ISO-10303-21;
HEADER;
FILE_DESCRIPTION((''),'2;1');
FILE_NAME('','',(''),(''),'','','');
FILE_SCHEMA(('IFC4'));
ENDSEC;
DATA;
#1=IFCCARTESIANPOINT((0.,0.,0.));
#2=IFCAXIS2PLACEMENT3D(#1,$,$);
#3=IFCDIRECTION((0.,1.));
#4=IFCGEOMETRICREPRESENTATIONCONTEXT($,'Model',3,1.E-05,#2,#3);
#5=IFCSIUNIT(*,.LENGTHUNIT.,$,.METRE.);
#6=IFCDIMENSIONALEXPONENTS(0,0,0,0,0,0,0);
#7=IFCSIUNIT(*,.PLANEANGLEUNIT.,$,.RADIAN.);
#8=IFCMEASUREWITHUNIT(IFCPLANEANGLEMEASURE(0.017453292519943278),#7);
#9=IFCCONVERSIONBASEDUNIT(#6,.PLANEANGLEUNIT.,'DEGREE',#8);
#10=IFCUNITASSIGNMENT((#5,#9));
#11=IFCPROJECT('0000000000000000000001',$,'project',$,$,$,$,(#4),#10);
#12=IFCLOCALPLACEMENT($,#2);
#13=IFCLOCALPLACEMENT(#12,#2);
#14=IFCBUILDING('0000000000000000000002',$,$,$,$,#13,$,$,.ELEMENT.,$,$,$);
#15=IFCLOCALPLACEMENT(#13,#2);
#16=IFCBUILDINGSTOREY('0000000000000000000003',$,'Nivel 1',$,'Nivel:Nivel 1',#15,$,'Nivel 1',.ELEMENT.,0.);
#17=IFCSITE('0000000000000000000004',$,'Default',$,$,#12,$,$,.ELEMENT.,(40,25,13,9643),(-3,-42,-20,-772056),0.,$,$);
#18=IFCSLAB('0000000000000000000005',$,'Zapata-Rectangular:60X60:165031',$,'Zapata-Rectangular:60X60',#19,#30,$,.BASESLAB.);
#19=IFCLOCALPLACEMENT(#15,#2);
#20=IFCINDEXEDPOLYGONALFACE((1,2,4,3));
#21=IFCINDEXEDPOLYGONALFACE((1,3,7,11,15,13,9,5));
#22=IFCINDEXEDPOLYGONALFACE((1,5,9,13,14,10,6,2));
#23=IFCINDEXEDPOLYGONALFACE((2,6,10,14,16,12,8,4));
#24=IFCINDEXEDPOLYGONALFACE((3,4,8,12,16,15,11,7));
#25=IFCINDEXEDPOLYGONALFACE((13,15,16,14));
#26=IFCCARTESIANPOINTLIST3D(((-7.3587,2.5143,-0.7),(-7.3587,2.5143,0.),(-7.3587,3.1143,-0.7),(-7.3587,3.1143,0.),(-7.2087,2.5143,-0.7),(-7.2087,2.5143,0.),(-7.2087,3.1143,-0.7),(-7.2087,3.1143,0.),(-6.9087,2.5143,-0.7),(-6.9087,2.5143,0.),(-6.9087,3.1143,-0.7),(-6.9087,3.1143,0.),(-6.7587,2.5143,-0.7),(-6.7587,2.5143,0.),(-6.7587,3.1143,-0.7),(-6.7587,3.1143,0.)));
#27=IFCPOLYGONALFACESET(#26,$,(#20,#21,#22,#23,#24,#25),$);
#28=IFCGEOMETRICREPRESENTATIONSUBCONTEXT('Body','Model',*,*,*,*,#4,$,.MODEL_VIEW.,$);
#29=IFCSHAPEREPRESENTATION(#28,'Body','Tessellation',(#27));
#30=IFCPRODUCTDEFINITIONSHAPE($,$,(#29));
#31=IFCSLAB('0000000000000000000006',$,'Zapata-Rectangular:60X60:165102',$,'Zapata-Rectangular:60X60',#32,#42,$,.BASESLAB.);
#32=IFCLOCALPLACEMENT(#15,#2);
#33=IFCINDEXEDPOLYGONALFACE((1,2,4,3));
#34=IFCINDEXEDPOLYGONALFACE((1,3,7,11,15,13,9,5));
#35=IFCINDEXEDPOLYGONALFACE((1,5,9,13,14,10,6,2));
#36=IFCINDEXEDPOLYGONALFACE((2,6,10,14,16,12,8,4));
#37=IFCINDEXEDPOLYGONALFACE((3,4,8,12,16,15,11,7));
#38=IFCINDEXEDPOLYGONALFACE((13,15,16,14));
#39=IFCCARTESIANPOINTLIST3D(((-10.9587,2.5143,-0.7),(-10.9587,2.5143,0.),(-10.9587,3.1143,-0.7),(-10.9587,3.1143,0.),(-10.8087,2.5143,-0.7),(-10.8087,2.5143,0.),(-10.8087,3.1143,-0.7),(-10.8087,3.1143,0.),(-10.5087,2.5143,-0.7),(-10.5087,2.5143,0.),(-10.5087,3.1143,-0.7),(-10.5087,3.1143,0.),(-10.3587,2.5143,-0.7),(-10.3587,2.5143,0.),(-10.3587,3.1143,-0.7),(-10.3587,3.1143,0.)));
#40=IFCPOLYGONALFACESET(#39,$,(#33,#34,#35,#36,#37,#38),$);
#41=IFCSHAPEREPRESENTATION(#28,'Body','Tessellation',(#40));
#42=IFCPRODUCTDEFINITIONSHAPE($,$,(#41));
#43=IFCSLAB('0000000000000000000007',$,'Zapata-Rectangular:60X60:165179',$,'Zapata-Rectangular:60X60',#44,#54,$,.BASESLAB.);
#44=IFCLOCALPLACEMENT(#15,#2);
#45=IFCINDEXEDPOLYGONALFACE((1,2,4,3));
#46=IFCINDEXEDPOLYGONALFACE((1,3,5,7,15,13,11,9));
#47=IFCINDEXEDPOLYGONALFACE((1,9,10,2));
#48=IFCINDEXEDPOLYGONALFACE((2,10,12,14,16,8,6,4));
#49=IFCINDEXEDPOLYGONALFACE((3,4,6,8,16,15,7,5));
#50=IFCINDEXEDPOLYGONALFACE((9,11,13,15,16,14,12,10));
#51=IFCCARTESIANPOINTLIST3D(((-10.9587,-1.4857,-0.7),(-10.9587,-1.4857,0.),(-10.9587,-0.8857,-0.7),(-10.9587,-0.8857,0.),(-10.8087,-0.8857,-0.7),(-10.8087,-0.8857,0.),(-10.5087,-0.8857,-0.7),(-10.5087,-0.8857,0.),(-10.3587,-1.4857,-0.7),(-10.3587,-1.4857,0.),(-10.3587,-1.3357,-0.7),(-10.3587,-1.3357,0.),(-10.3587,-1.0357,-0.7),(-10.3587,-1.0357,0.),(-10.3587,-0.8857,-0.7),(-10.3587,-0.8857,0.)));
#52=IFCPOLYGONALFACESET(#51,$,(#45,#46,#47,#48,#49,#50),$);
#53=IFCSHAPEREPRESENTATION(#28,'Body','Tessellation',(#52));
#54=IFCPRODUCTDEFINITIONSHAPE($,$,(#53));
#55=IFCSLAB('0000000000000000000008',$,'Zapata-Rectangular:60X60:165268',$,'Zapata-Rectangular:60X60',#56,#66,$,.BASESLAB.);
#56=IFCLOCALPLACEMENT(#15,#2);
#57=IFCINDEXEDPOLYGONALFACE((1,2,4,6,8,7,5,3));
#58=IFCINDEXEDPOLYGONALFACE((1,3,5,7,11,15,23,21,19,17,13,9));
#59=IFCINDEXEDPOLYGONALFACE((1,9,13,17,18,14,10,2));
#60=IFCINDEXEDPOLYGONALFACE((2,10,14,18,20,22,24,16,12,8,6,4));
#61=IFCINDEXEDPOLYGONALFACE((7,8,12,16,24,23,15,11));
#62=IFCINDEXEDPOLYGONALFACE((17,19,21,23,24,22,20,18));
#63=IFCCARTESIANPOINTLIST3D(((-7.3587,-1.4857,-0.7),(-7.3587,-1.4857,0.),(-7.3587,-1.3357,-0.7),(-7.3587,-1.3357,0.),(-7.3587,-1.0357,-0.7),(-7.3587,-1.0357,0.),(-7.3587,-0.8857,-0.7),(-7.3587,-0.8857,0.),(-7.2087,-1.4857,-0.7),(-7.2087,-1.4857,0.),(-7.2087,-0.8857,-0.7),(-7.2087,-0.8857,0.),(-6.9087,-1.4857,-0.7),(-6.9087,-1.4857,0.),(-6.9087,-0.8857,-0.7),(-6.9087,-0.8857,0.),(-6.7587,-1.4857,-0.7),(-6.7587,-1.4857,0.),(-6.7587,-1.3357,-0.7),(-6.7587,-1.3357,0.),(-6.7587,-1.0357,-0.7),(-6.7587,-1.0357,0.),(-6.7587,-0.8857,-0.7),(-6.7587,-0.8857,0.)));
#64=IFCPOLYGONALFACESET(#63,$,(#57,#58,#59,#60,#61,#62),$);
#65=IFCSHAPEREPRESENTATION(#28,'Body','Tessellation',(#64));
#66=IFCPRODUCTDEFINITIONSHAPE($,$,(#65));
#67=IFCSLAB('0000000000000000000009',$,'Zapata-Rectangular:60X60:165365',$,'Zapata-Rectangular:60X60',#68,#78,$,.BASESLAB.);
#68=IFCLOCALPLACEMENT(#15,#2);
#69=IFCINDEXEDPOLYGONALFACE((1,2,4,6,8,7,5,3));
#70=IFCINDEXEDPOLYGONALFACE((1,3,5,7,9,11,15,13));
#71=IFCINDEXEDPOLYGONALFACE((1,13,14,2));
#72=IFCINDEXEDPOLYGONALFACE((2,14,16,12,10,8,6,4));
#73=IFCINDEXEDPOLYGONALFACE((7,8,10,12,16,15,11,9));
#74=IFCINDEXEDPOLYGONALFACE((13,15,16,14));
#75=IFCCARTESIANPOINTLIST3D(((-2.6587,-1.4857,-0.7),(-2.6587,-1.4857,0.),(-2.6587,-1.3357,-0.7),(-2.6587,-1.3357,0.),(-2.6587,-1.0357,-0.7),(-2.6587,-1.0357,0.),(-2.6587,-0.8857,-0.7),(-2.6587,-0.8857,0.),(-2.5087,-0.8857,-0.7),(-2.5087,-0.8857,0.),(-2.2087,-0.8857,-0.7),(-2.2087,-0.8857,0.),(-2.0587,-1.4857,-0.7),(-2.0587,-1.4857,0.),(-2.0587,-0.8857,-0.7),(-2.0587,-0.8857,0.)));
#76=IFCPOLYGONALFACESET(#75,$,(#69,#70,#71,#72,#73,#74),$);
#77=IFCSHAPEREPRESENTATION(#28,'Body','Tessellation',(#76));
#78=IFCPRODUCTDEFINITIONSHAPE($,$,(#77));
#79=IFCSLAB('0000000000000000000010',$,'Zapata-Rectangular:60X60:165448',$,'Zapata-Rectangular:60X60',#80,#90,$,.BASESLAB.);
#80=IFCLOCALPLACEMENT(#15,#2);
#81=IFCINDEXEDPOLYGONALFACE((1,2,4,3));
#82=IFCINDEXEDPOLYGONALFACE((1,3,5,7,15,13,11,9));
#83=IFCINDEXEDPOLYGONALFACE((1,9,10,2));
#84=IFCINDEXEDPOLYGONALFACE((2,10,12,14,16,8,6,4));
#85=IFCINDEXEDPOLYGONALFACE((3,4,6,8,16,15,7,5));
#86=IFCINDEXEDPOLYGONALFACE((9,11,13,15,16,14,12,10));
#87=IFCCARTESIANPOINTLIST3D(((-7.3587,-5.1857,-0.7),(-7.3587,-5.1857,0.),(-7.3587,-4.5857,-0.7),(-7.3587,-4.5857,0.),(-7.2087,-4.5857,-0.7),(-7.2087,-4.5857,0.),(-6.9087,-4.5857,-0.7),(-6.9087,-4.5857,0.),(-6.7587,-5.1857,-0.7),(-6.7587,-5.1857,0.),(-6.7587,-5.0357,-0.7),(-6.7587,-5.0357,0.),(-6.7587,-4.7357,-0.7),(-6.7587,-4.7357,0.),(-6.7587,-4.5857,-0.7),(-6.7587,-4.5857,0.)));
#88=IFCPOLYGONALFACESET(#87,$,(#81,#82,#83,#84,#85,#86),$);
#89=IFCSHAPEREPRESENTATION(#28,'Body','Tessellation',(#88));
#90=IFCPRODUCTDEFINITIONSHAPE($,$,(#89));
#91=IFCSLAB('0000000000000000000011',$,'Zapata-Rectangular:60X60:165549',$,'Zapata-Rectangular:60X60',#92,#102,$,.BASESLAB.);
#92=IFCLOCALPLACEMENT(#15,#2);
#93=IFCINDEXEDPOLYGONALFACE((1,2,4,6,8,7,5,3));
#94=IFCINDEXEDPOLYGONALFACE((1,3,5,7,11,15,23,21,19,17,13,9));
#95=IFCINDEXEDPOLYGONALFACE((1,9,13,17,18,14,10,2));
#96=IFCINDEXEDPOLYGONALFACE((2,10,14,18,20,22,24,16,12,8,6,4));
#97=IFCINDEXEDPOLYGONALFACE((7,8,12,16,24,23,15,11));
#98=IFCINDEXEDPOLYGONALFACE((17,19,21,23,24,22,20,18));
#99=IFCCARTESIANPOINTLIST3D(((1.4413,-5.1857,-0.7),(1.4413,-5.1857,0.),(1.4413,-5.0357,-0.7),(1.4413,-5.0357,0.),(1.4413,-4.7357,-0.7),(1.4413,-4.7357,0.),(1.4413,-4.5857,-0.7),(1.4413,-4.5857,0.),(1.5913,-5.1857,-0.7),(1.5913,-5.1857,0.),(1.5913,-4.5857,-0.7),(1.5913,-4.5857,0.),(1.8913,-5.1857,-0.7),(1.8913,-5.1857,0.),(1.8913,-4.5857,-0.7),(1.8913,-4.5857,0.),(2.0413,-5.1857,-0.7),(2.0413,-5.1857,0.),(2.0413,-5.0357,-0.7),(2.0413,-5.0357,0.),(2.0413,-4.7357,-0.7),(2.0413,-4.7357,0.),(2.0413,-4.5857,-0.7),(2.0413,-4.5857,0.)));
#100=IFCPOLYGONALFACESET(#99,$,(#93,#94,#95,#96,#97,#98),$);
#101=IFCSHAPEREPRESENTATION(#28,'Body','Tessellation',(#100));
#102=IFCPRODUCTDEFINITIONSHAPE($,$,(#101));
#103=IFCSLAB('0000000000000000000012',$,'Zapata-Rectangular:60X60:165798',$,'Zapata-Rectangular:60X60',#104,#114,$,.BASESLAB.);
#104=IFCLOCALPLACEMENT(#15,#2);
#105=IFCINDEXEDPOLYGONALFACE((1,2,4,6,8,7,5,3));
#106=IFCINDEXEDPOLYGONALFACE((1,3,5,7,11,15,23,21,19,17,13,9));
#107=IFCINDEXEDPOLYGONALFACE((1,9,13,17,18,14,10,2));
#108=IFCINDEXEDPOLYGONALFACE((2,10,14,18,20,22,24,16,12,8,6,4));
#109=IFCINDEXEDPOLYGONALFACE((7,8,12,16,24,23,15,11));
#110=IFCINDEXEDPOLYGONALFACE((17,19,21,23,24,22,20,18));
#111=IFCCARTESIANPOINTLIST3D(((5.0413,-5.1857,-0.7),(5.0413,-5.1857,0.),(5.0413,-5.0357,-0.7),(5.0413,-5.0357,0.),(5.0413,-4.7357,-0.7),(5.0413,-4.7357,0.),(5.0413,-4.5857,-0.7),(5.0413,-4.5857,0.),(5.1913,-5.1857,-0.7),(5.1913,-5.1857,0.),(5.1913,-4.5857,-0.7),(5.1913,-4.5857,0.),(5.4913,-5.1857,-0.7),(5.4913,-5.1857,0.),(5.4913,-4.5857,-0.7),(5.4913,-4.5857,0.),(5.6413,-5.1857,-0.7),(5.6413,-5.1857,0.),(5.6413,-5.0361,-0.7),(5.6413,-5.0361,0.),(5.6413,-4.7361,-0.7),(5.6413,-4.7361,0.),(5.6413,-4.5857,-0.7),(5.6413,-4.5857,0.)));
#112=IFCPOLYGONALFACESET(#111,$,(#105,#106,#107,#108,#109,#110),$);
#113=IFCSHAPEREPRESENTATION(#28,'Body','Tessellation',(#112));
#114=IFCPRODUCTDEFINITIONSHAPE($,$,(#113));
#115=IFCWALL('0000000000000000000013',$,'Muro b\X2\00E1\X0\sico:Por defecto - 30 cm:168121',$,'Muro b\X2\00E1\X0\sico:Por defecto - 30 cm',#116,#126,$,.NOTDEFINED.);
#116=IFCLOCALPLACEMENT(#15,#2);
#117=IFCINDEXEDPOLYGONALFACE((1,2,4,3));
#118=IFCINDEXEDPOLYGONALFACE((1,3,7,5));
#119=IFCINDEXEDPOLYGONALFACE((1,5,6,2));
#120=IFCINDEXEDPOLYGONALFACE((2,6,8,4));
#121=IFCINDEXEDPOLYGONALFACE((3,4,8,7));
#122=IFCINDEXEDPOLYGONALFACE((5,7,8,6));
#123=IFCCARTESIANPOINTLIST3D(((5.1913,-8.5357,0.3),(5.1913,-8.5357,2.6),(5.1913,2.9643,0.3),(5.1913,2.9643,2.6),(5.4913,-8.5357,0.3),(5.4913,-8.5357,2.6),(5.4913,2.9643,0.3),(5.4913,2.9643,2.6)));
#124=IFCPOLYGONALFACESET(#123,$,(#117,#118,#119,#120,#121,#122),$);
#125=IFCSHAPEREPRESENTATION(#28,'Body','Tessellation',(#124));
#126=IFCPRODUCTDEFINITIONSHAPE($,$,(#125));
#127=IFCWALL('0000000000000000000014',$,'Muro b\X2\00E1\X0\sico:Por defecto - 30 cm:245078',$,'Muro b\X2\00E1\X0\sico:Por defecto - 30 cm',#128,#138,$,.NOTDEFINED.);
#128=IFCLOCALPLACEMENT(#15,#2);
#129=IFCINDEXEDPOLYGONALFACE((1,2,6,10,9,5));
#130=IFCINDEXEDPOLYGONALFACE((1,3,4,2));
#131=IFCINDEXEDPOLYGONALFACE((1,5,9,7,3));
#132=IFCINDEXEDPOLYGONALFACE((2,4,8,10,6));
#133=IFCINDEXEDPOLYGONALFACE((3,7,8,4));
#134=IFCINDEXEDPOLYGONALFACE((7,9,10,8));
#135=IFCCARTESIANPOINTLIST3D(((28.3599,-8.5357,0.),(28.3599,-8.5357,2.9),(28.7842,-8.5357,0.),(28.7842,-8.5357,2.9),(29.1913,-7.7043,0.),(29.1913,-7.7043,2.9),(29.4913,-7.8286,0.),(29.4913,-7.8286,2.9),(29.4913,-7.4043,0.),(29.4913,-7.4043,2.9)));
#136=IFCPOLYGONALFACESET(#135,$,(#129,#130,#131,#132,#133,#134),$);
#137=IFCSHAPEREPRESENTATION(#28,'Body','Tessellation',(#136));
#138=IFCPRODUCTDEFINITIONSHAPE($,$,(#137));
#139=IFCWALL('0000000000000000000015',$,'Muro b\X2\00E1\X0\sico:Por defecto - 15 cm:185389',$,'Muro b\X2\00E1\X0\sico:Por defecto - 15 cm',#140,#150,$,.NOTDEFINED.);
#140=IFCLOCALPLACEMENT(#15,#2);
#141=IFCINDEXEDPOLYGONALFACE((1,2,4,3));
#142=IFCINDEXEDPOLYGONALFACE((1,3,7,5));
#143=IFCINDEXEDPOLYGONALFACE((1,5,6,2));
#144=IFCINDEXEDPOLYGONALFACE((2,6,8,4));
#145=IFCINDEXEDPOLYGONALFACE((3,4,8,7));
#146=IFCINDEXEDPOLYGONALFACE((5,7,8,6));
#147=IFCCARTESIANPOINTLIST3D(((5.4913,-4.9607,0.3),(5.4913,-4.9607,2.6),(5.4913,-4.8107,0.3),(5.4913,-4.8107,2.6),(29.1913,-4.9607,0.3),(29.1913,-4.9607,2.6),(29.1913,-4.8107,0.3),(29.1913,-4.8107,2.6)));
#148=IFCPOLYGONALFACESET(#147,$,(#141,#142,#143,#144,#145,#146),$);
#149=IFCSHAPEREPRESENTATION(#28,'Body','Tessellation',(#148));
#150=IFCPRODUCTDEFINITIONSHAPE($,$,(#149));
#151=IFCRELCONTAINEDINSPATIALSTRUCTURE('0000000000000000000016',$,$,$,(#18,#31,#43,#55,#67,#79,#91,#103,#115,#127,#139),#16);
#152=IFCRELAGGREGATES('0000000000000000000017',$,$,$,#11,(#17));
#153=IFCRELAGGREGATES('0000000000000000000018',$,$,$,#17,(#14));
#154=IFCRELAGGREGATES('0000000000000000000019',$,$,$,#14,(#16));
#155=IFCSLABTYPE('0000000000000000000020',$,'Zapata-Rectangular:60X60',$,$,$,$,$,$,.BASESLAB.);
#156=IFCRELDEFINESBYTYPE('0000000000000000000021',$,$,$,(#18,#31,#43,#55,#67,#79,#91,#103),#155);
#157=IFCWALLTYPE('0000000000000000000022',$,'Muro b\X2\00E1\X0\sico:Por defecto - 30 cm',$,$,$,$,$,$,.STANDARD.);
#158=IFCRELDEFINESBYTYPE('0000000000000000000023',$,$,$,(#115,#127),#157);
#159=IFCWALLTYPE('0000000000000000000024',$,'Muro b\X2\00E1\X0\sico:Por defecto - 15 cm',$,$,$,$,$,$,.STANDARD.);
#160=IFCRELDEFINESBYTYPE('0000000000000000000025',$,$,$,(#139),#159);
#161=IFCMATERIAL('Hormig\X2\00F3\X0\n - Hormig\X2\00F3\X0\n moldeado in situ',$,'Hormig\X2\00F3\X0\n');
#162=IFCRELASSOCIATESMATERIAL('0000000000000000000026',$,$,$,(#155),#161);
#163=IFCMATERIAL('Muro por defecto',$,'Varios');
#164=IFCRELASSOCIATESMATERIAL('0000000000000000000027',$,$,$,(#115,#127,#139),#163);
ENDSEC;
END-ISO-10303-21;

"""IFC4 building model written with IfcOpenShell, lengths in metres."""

from ifc_helpers import new_model, entity, si_unit, converted_unit, direction, frame, origin, place, context, subcontext, project, spatial, indexed_curve, outline, extrude, material, type_object, element, save


model = new_model("IFC4")

# Units and contexts
model_context = context("Model", 3, precision=1e-05, world=origin(), true_north=direction((0.0, 1.0)))
body_context = subcontext(model_context, "Body", "Model", "MODEL_VIEW")
ifc_project = project(units=[si_unit("LENGTHUNIT", "METRE"), converted_unit("PLANEANGLEUNIT", "DEGREE", entity("IfcPlaneAngleMeasure", 0.017453292519943278), si_unit("PLANEANGLEUNIT", "RADIAN"), dimensions=[0, 0, 0, 0, 0, 0, 0])], contexts=[model_context])

# Site, building, storey
site_placement = place(None, origin())
site = spatial("IfcSite", under=ifc_project, at=site_placement, Name="Default", CompositionType="ELEMENT", RefLatitude=(40, 25, 13, 9643), RefLongitude=(-3, -42, -20, -772056), RefElevation=0.0)
building_placement = place(site_placement, origin())
building = spatial("IfcBuilding", under=site, at=building_placement, CompositionType="ELEMENT")
storey_placement = place(building_placement, origin())
storey = spatial("IfcBuildingStorey", under=building, at=storey_placement, Name="Nivel 1", ObjectType="Nivel:Nivel 1", LongName="Nivel 1", CompositionType="ELEMENT", Elevation=0.0)

# Slabs
ifc_material_1 = material(Name="Hormigón - Hormigón moldeado in situ", Category="Hormigón")
slab_type = type_object("IfcSlabType", Name="Zapata-Rectangular:60X60", PredefinedType="BASESLAB", material=ifc_material_1)
slab_1_placement = place(storey_placement, origin())
element("IfcSlab", 1, at=slab_1_placement, inside=storey, type_object=slab_type, Name="Zapata-Rectangular:60X60:165031", ObjectType="Zapata-Rectangular:60X60", PredefinedType="BASESLAB", context=body_context, shape_type="SweptSolid", body=[
    extrude(outline(indexed_curve([(-0.3, -0.3), (-0.15, -0.3), (0.15, -0.3), (0.3, -0.3), (0.3, 0.3), (0.15, 0.3), (-0.15, 0.3), (-0.3, 0.3), (-0.3, -0.3)], self_intersect=False)), frame((-7.0587, 2.8143, -0.7), z_axis=(0.0, 0.0, 1.0), x_axis=(-1.0, 0.0, 0.0)), (0.0, 0.0, 1.0), 0.7),
])
slab_2_placement = place(storey_placement, origin())
element("IfcSlab", 2, at=slab_2_placement, inside=storey, type_object=slab_type, Name="Zapata-Rectangular:60X60:165102", ObjectType="Zapata-Rectangular:60X60", PredefinedType="BASESLAB", context=body_context, shape_type="SweptSolid", body=[
    extrude(outline(indexed_curve([(-0.3, -0.3), (-0.15, -0.3), (0.15, -0.3), (0.3, -0.3), (0.3, 0.3), (0.15, 0.3), (-0.15, 0.3), (-0.3, 0.3), (-0.3, -0.3)], self_intersect=False)), frame((-10.6587, 2.8143, -0.7), z_axis=(0.0, 0.0, 1.0), x_axis=(-1.0, 0.0, 0.0)), (0.0, 0.0, 1.0), 0.7),
])
slab_3_placement = place(storey_placement, origin())
element("IfcSlab", 3, at=slab_3_placement, inside=storey, type_object=slab_type, Name="Zapata-Rectangular:60X60:165179", ObjectType="Zapata-Rectangular:60X60", PredefinedType="BASESLAB", context=body_context, shape_type="SweptSolid", body=[
    extrude(outline(indexed_curve([(-0.225, -0.225), (-0.075, -0.225), (0.225, -0.225), (0.375, -0.225), (0.375, 0.375), (-0.225, 0.375), (-0.225, 0.225), (-0.225, -0.075), (-0.225, -0.225)], self_intersect=False)), frame((-10.5837, -1.1107, -0.7), z_axis=(0.0, 0.0, 1.0), x_axis=(-1.0, 0.0, 0.0)), (0.0, 0.0, 1.0), 0.7),
])
slab_4_placement = place(storey_placement, origin())
element("IfcSlab", 4, at=slab_4_placement, inside=storey, type_object=slab_type, Name="Zapata-Rectangular:60X60:165268", ObjectType="Zapata-Rectangular:60X60", PredefinedType="BASESLAB", context=body_context, shape_type="SweptSolid", body=[
    extrude(outline(indexed_curve([(-0.3, -0.3), (-0.15, -0.3), (0.15, -0.3), (0.3, -0.3), (0.3, -0.15), (0.3, 0.15), (0.3, 0.3), (0.15, 0.3), (-0.15, 0.3), (-0.3, 0.3), (-0.3, 0.15), (-0.3, -0.15), (-0.3, -0.3)], self_intersect=False)), frame((-7.0587, -1.1857, -0.7), z_axis=(0.0, 0.0, 1.0), x_axis=(-1.0, 0.0, 0.0)), (0.0, 0.0, 1.0), 0.7),
])
slab_5_placement = place(storey_placement, origin())
element("IfcSlab", 5, at=slab_5_placement, inside=storey, type_object=slab_type, Name="Zapata-Rectangular:60X60:165365", ObjectType="Zapata-Rectangular:60X60", PredefinedType="BASESLAB", context=body_context, shape_type="SweptSolid", body=[
    extrude(outline(indexed_curve([(-0.375, -0.225), (-0.225, -0.225), (0.075, -0.225), (0.225, -0.225), (0.225, -0.075), (0.225, 0.225), (0.225, 0.375), (-0.375, 0.375), (-0.375, -0.225)], self_intersect=False)), frame((-2.4337, -1.1107, -0.7), z_axis=(0.0, 0.0, 1.0), x_axis=(-1.0, 0.0, 0.0)), (0.0, 0.0, 1.0), 0.7),
])
slab_6_placement = place(storey_placement, origin())
element("IfcSlab", 6, at=slab_6_placement, inside=storey, type_object=slab_type, Name="Zapata-Rectangular:60X60:165448", ObjectType="Zapata-Rectangular:60X60", PredefinedType="BASESLAB", context=body_context, shape_type="SweptSolid", body=[
    extrude(outline(indexed_curve([(-0.225, -0.225), (-0.075, -0.225), (0.225, -0.225), (0.375, -0.225), (0.375, 0.375), (-0.225, 0.375), (-0.225, 0.225), (-0.225, -0.075), (-0.225, -0.225)], self_intersect=False)), frame((-6.9837, -4.8107, -0.7), z_axis=(0.0, 0.0, 1.0), x_axis=(-1.0, 0.0, 0.0)), (0.0, 0.0, 1.0), 0.7),
])
slab_7_placement = place(storey_placement, origin())
element("IfcSlab", 7, at=slab_7_placement, inside=storey, type_object=slab_type, Name="Zapata-Rectangular:60X60:165549", ObjectType="Zapata-Rectangular:60X60", PredefinedType="BASESLAB", context=body_context, shape_type="SweptSolid", body=[
    extrude(outline(indexed_curve([(-0.3, -0.3), (-0.15, -0.3), (0.15, -0.3), (0.3, -0.3), (0.3, -0.15), (0.3, 0.15), (0.3, 0.3), (0.15, 0.3), (-0.15, 0.3), (-0.3, 0.3), (-0.3, 0.15), (-0.3, -0.15), (-0.3, -0.3)], self_intersect=False)), frame((1.7413, -4.8857, -0.7), z_axis=(0.0, 0.0, 1.0), x_axis=(-1.0, 0.0, 0.0)), (0.0, 0.0, 1.0), 0.7),
])
slab_8_placement = place(storey_placement, origin())
element("IfcSlab", 8, at=slab_8_placement, inside=storey, type_object=slab_type, Name="Zapata-Rectangular:60X60:165798", ObjectType="Zapata-Rectangular:60X60", PredefinedType="BASESLAB", context=body_context, shape_type="SweptSolid", body=[
    extrude(outline(indexed_curve([(-0.3, -0.3001), (-0.15, -0.3001), (0.15, -0.3001), (0.3, -0.3001), (0.3, -0.1501), (0.3, 0.1499), (0.3, 0.2999), (0.15, 0.2999), (-0.15, 0.2999), (-0.3, 0.2999), (-0.3, 0.1503), (-0.3, -0.1497), (-0.3, -0.3001)], self_intersect=False)), frame((5.3413, -4.8858, -0.7), z_axis=(0.0, 0.0, 1.0), x_axis=(-1.0, 0.0, 0.0)), (0.0, 0.0, 1.0), 0.7),
])

# Walls
ifc_material_2 = material(Name="Muro por defecto", Category="Varios")
wall_type_1 = type_object("IfcWallType", Name="Muro básico:Por defecto - 30 cm", PredefinedType="STANDARD")
wall_1_placement = place(storey_placement, frame((5.3413, -8.5357, 0.3), z_axis=(0.0, 0.0, 1.0), x_axis=(0.0, 1.0, 0.0)))
element("IfcWall", 9, at=wall_1_placement, inside=storey, type_object=wall_type_1, material=ifc_material_2, Name="Muro básico:Por defecto - 30 cm:168121", ObjectType="Muro básico:Por defecto - 30 cm", PredefinedType="NOTDEFINED", context=body_context, shape_type="SweptSolid", body=[
    extrude(outline(indexed_curve([(11.5, 0.15), (0.0, 0.15), (0.0, -0.15), (11.5, -0.15), (11.5, 0.15)], self_intersect=False)), origin(), (0.0, 0.0, 1.0), 2.3),
])
wall_2_placement = place(storey_placement, frame((29.5974, -7.5104, 0.0), z_axis=(0.0, 0.0, 1.0), x_axis=(-0.707107, -0.707107, 0.0)))
element("IfcWall", 10, at=wall_2_placement, inside=storey, type_object=wall_type_1, material=ifc_material_2, Name="Muro básico:Por defecto - 30 cm:245078", ObjectType="Muro básico:Por defecto - 30 cm", PredefinedType="NOTDEFINED", context=body_context, shape_type="SweptSolid", body=[
    extrude(outline(indexed_curve([(1.6, -0.15), (1.3, 0.15), (0.3, 0.15), (0.0, -0.15), (0.4243, -0.15), (1.6, -0.15)], self_intersect=False)), origin(), (0.0, 0.0, 1.0), 2.9),
])
wall_type_2 = type_object("IfcWallType", Name="Muro básico:Por defecto - 15 cm", PredefinedType="STANDARD")
wall_3_placement = place(storey_placement, frame((5.4913, -4.8857, 0.3)))
element("IfcWall", 11, at=wall_3_placement, inside=storey, type_object=wall_type_2, material=ifc_material_2, Name="Muro básico:Por defecto - 15 cm:185389", ObjectType="Muro básico:Por defecto - 15 cm", PredefinedType="NOTDEFINED", context=body_context, shape_type="SweptSolid", body=[
    extrude(outline(indexed_curve([(23.7, 0.075), (0.0, 0.075), (0.0, -0.075), (23.7, -0.075), (23.7, 0.075)], self_intersect=False)), origin(), (0.0, 0.0, 1.0), 2.3),
])

save(model, "model.ifc")
